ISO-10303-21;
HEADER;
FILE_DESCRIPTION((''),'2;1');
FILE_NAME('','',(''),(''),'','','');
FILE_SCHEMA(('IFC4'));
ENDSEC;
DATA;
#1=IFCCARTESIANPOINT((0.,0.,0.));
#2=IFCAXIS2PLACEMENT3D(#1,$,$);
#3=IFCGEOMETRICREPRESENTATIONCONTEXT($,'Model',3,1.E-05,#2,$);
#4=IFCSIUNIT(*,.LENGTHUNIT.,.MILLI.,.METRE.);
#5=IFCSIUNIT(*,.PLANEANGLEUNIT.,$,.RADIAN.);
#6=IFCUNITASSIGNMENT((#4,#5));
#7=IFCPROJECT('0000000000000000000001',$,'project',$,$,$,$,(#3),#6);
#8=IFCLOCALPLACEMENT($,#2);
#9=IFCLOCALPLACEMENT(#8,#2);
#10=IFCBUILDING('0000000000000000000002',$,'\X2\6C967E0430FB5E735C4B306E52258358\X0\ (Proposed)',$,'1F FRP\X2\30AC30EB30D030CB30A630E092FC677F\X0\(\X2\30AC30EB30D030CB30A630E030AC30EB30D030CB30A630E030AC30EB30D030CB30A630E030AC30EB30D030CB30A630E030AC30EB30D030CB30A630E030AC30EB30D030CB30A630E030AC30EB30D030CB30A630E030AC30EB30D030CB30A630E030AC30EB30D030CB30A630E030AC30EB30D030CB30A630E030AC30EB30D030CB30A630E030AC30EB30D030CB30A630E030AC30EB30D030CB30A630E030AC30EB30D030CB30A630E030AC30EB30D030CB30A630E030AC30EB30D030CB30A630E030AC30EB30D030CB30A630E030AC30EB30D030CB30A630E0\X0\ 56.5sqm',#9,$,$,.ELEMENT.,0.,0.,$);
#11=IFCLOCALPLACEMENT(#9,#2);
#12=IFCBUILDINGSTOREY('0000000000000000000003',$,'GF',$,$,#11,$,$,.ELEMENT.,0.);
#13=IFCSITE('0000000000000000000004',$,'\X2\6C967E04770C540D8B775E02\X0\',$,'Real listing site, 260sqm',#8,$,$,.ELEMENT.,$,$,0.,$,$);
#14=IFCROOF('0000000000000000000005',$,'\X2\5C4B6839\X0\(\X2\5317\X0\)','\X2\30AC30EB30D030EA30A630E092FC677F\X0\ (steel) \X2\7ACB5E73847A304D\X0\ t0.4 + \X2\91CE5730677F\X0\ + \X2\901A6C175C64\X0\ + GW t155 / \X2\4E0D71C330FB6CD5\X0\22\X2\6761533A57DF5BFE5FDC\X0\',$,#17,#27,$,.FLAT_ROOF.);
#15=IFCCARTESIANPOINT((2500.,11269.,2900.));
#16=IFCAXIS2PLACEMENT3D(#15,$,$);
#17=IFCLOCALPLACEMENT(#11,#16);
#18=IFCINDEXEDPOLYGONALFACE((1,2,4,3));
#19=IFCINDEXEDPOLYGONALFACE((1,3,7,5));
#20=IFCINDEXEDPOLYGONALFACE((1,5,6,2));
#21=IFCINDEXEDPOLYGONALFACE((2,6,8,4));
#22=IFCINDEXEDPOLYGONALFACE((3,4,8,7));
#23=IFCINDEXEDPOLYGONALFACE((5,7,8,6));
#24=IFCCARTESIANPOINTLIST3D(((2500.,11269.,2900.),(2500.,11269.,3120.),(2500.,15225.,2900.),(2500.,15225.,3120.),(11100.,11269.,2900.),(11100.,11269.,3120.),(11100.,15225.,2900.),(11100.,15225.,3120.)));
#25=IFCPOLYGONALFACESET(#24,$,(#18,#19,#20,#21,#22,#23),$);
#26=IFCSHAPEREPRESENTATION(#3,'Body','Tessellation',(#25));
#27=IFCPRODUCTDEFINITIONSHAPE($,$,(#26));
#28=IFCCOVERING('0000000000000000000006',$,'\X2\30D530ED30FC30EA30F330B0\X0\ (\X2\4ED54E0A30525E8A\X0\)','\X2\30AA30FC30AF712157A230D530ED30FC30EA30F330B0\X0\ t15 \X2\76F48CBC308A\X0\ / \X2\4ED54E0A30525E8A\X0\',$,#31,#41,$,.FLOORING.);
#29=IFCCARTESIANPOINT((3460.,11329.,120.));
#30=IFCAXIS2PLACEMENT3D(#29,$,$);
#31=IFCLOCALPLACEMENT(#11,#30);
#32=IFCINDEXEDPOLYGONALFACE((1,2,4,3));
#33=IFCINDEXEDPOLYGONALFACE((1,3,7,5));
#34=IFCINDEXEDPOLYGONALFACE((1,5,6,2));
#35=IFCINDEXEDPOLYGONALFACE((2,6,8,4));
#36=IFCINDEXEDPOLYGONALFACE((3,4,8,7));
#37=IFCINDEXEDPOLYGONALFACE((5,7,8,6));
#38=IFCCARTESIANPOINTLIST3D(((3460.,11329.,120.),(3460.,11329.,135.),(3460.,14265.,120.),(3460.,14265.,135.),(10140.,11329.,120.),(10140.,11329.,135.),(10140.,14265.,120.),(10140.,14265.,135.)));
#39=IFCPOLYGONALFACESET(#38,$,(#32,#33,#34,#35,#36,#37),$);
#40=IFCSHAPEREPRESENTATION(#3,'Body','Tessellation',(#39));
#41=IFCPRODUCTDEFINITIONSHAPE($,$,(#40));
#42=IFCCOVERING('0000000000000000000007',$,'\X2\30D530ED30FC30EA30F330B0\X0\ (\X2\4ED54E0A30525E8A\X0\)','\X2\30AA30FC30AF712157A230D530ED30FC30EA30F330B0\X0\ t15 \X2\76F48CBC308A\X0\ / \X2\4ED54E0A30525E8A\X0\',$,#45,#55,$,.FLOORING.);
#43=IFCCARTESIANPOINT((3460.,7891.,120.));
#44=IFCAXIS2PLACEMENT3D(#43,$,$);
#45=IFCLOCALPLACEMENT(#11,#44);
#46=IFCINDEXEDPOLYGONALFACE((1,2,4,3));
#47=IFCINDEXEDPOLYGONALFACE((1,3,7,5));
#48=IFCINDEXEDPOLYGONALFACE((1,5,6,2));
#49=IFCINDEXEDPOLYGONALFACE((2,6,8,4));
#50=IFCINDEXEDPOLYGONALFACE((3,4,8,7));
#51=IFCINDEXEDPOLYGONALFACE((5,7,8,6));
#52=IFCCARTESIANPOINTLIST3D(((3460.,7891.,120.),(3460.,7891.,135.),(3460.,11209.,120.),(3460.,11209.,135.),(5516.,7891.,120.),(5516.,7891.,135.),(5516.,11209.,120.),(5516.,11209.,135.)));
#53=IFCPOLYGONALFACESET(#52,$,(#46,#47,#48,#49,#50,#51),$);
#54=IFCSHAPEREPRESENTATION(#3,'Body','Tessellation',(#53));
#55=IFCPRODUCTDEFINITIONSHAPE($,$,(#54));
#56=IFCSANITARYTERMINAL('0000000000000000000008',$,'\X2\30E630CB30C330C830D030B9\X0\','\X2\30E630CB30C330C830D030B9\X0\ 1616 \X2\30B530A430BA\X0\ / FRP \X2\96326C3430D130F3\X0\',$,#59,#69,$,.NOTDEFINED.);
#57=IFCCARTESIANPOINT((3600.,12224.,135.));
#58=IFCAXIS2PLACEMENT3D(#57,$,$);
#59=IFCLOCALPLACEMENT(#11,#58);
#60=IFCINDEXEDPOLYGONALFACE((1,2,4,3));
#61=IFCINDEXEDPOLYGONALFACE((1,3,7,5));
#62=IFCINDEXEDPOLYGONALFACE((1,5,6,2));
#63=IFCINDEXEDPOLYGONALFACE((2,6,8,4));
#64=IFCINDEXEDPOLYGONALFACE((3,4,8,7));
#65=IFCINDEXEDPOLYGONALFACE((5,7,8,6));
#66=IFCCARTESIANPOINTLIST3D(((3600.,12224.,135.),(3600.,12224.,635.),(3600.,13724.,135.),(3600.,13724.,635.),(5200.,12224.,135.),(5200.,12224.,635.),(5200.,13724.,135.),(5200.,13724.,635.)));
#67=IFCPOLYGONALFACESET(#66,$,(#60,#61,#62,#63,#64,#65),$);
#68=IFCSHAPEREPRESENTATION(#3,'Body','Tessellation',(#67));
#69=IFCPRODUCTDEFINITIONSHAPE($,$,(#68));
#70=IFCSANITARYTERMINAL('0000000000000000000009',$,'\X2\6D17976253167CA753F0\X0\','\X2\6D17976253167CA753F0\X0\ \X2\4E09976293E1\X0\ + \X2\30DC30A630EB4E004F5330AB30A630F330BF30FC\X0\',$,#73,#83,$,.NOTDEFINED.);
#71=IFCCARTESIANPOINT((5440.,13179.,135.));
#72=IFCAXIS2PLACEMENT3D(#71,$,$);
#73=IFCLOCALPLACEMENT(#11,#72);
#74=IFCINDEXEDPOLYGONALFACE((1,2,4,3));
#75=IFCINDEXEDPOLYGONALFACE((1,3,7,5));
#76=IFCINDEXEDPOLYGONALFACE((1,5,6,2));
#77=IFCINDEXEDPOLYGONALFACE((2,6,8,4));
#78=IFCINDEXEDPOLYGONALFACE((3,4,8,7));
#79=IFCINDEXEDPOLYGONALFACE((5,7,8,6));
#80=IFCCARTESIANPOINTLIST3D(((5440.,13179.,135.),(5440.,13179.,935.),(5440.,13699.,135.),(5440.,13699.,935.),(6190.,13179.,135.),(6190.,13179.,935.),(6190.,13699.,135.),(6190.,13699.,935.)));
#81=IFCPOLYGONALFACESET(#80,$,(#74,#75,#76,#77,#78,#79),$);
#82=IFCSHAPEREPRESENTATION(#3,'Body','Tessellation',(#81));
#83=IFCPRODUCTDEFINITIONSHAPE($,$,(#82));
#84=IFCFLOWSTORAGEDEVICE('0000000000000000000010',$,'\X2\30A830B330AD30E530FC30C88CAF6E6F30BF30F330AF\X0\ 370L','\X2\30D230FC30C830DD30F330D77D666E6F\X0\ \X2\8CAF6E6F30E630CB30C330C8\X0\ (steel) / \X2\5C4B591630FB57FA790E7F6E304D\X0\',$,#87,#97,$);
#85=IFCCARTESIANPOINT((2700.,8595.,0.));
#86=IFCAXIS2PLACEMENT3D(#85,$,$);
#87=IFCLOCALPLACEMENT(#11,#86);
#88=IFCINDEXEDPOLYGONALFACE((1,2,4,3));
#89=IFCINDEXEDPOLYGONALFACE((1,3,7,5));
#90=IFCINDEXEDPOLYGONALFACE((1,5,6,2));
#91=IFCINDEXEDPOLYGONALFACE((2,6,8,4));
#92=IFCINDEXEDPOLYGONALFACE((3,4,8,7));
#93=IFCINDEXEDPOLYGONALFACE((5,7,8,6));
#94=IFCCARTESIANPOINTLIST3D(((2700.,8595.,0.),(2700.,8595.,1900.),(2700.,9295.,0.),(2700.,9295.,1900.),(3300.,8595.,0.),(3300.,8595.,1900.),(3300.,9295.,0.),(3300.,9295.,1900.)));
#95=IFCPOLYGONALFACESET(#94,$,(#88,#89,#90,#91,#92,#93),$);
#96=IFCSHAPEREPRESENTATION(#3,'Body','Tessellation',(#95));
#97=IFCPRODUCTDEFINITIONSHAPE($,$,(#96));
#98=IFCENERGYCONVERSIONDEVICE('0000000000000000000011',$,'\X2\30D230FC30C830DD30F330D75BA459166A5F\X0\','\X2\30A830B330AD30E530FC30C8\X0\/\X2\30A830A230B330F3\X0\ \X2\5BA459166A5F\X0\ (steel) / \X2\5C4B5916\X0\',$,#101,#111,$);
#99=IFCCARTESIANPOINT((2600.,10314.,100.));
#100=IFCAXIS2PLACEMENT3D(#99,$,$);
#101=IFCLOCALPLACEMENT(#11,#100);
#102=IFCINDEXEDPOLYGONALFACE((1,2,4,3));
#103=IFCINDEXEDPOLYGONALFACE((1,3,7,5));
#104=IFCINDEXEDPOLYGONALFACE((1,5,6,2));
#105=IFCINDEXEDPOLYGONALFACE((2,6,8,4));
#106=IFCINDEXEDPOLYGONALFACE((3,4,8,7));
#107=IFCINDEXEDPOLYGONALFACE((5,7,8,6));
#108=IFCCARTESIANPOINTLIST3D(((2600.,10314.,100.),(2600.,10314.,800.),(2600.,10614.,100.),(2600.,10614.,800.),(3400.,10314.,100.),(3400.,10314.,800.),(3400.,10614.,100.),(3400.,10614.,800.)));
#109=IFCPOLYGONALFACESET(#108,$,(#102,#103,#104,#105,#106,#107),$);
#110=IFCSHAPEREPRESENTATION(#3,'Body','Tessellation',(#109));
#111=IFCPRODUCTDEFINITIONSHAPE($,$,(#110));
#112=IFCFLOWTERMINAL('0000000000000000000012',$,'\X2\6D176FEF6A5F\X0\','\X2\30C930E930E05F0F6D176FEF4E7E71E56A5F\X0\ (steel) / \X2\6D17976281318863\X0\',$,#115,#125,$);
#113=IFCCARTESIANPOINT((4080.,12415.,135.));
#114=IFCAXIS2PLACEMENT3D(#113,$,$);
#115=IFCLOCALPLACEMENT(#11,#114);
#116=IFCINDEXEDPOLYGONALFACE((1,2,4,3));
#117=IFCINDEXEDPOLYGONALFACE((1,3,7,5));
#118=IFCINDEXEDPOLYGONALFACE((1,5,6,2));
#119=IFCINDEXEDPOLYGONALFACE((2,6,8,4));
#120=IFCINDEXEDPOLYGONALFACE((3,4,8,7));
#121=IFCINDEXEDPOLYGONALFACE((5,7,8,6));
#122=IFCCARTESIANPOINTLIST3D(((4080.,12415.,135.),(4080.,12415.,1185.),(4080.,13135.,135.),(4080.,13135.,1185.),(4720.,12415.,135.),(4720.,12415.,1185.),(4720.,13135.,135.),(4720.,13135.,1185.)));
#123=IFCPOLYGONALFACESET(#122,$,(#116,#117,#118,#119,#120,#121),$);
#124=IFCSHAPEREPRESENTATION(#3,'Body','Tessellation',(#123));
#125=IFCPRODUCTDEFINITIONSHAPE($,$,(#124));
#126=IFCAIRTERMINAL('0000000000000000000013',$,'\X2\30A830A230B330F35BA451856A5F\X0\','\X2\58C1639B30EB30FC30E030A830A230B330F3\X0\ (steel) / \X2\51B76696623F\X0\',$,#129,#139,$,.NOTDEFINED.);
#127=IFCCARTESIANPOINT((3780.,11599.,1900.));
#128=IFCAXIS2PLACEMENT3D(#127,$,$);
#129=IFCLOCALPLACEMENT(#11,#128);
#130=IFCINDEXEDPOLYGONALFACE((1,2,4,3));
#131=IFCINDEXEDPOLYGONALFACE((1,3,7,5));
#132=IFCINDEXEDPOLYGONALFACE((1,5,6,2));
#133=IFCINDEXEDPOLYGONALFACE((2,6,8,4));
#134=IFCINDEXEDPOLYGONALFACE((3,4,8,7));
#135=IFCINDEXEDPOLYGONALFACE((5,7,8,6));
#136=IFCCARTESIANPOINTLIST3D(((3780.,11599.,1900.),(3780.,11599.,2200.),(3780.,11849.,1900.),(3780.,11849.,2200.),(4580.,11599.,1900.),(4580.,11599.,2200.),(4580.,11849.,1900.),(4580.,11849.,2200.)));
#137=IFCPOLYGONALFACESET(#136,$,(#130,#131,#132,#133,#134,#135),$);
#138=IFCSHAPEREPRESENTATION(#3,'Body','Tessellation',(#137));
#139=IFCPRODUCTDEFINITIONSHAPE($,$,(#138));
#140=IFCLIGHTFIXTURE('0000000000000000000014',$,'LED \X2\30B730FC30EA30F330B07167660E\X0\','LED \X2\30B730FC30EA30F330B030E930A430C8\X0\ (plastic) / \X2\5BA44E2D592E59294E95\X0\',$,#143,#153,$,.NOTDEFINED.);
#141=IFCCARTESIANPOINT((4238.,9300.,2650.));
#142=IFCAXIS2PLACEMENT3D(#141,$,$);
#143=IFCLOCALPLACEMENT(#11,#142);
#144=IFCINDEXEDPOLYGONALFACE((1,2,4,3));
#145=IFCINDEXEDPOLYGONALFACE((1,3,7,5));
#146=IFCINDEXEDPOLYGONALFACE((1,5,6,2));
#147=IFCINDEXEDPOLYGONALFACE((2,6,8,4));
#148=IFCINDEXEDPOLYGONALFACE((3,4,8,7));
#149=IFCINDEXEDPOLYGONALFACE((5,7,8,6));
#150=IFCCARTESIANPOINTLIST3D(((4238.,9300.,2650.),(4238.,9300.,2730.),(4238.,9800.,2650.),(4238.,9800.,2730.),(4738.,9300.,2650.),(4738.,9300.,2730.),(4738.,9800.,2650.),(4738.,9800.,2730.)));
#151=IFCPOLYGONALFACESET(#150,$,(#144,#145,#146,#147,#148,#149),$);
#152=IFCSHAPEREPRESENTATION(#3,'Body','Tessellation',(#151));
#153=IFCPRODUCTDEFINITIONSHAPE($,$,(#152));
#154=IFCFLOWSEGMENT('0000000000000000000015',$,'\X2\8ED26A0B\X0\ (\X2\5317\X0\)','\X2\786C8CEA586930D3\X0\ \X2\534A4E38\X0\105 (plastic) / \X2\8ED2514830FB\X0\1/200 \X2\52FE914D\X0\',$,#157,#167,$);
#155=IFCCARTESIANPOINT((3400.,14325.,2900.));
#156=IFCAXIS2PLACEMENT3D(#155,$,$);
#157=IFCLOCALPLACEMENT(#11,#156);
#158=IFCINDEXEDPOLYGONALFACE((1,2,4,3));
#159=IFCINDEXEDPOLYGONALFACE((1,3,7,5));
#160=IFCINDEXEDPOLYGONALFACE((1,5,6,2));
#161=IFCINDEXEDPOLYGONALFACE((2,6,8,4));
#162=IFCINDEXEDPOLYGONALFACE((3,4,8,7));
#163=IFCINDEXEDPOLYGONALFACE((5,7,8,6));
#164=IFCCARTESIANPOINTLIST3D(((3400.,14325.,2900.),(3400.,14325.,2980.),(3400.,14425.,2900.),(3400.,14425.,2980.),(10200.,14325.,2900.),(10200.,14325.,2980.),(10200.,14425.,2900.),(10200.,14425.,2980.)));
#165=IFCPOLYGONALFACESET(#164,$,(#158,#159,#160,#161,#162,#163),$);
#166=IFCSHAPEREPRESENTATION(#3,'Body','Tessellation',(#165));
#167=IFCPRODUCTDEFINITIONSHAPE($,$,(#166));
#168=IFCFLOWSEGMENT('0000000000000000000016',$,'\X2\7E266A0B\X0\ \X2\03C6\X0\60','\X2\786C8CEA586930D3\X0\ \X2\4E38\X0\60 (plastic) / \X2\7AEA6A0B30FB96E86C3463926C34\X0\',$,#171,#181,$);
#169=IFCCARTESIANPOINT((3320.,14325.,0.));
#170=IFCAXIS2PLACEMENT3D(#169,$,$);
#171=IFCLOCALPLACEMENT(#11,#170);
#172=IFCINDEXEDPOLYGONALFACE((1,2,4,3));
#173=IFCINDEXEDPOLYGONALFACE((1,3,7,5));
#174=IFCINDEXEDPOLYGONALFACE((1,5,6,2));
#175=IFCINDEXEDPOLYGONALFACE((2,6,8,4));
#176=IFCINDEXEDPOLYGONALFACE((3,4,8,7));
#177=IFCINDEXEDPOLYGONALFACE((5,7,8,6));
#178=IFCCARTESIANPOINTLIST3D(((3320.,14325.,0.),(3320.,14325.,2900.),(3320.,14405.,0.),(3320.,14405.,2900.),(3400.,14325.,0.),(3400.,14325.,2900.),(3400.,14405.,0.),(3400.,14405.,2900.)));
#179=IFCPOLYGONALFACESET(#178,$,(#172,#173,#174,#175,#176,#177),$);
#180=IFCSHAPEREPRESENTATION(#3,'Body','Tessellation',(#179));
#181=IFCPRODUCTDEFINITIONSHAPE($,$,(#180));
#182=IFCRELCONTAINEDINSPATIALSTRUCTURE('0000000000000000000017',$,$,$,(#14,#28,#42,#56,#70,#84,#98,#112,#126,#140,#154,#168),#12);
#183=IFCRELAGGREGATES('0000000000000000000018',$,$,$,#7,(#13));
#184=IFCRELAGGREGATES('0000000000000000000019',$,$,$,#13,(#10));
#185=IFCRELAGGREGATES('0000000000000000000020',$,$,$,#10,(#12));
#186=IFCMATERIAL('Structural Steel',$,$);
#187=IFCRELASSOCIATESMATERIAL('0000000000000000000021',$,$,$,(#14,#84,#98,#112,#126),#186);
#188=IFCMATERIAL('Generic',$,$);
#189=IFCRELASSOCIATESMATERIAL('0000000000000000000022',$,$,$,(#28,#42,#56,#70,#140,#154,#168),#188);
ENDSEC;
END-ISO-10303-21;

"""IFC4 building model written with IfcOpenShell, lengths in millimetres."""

from ifc_helpers import new_model, si_unit, frame, frame_2d, origin, place, context, project, spatial, rectangle, extrude, material, element, save


model = new_model("IFC4")

# Units and contexts
model_context = context("Model", 3, precision=1e-05, world=origin())
ifc_project = project(units=[si_unit("LENGTHUNIT", "METRE", prefix="MILLI"), si_unit("PLANEANGLEUNIT", "RADIAN")], contexts=[model_context])

# Site, building, storey
site_placement = place(None, origin())
site = spatial("IfcSite", under=ifc_project, at=site_placement, Name="沖縄県名護市", ObjectType="Real listing site, 260sqm", CompositionType="ELEMENT", RefElevation=0.0)
building_placement = place(site_placement, origin())
building = spatial("IfcBuilding", under=site, at=building_placement, Name="沖縄・平屋の別荘 (Proposed)", ObjectType="1F FRPガルバニウム鋼板(ガルバニウムガルバニウムガルバニウムガルバニウムガルバニウムガルバニウムガルバニウムガルバニウムガルバニウムガルバニウムガルバニウムガルバニウムガルバニウムガルバニウムガルバニウムガルバニウムガルバニウムガルバニウム 56.5sqm", CompositionType="ELEMENT", ElevationOfRefHeight=0.0, ElevationOfTerrain=0.0)
storey_placement = place(building_placement, origin())
storey = spatial("IfcBuildingStorey", under=building, at=storey_placement, Name="GF", CompositionType="ELEMENT", Elevation=0.0)

# Roof
ifc_material_1 = material(Name="Structural Steel")
roof_placement = place(storey_placement, frame((2500.0, 11269.0, 2900.0)))
element("IfcRoof", 1, at=roof_placement, inside=storey, material=ifc_material_1, Name="屋根(北)", Description="ガルバリウム鋼板 (steel) 立平葺き t0.4 + 野地板 + 通気層 + GW t155 / 不燃・法22条区域対応", PredefinedType="FLAT_ROOF", context=model_context, shape_type="SweptSolid", body=[
    extrude(rectangle(XDim=8600.0, YDim=3956.0, at=frame_2d((4300.0, 1978.0))), frame((2500.0, 11269.0, 2900.0)), (0.0, 0.0, 1.0), 220.0),
])

# Coverings
ifc_material_2 = material(Name="Generic")
covering_1_placement = place(storey_placement, frame((3460.0, 11329.0, 120.0)))
element("IfcCovering", 2, at=covering_1_placement, inside=storey, material=ifc_material_2, Name="フローリング (仕上げ床)", Description="オーク無垢フローリング t15 直貼り / 仕上げ床", PredefinedType="FLOORING", context=model_context, shape_type="SweptSolid", body=[
    extrude(rectangle(XDim=6680.0, YDim=2936.0, at=frame_2d((3340.0, 1468.0))), frame((3460.0, 11329.0, 120.0)), (0.0, 0.0, 1.0), 15.0),
])
covering_2_placement = place(storey_placement, frame((3460.0, 7891.0, 120.0)))
element("IfcCovering", 3, at=covering_2_placement, inside=storey, material=ifc_material_2, Name="フローリング (仕上げ床)", Description="オーク無垢フローリング t15 直貼り / 仕上げ床", PredefinedType="FLOORING", context=model_context, shape_type="SweptSolid", body=[
    extrude(rectangle(XDim=2056.0, YDim=3318.0, at=frame_2d((1028.0, 1659.0))), frame((3460.0, 7891.0, 120.0)), (0.0, 0.0, 1.0), 15.0),
])

# Sanitary terminals
sanitary_terminal_1_placement = place(storey_placement, frame((3600.0, 12224.0, 135.0)))
element("IfcSanitaryTerminal", 4, at=sanitary_terminal_1_placement, inside=storey, material=ifc_material_2, Name="ユニットバス", Description="ユニットバス 1616 サイズ / FRP 防水パン", PredefinedType="NOTDEFINED", context=model_context, shape_type="SweptSolid", body=[
    extrude(rectangle(XDim=1600.0, YDim=1500.0, at=frame_2d((800.0, 750.0))), frame((3600.0, 12224.0, 135.0)), (0.0, 0.0, 1.0), 500.0),
])
sanitary_terminal_2_placement = place(storey_placement, frame((5440.0, 13179.0, 135.0)))
element("IfcSanitaryTerminal", 5, at=sanitary_terminal_2_placement, inside=storey, material=ifc_material_2, Name="洗面化粧台", Description="洗面化粧台 三面鏡 + ボウル一体カウンター", PredefinedType="NOTDEFINED", context=model_context, shape_type="SweptSolid", body=[
    extrude(rectangle(XDim=750.0, YDim=520.0, at=frame_2d((375.0, 260.0))), frame((5440.0, 13179.0, 135.0)), (0.0, 0.0, 1.0), 800.0),
])

# Flow storage device
flow_storage_device_placement = place(storey_placement, frame((2700.0, 8595.0, 0.0)))
element("IfcFlowStorageDevice", 6, at=flow_storage_device_placement, inside=storey, material=ifc_material_1, Name="エコキュート貯湯タンク 370L", Description="ヒートポンプ給湯 貯湯ユニット (steel) / 屋外・基礎置き", context=model_context, shape_type="SweptSolid", body=[
    extrude(rectangle(XDim=600.0, YDim=700.0, at=frame_2d((300.0, 350.0))), frame((2700.0, 8595.0, 0.0)), (0.0, 0.0, 1.0), 1900.0),
])

# Energy conversion device
energy_conversion_device_placement = place(storey_placement, frame((2600.0, 10314.0, 100.0)))
element("IfcEnergyConversionDevice", 7, at=energy_conversion_device_placement, inside=storey, material=ifc_material_1, Name="ヒートポンプ室外機", Description="エコキュート/エアコン 室外機 (steel) / 屋外", context=model_context, shape_type="SweptSolid", body=[
    extrude(rectangle(XDim=800.0, YDim=300.0, at=frame_2d((400.0, 150.0))), frame((2600.0, 10314.0, 100.0)), (0.0, 0.0, 1.0), 700.0),
])

# Flow terminal
flow_terminal_placement = place(storey_placement, frame((4080.0, 12415.0, 135.0)))
element("IfcFlowTerminal", 8, at=flow_terminal_placement, inside=storey, material=ifc_material_1, Name="洗濯機", Description="ドラム式洗濯乾燥機 (steel) / 洗面脱衣", context=model_context, shape_type="SweptSolid", body=[
    extrude(rectangle(XDim=640.0, YDim=720.0, at=frame_2d((320.0, 360.0))), frame((4080.0, 12415.0, 135.0)), (0.0, 0.0, 1.0), 1050.0),
])

# Air terminal
air_terminal_placement = place(storey_placement, frame((3780.0, 11599.0, 1900.0)))
element("IfcAirTerminal", 9, at=air_terminal_placement, inside=storey, material=ifc_material_1, Name="エアコン室内機", Description="壁掛ルームエアコン (steel) / 冷暖房", PredefinedType="NOTDEFINED", context=model_context, shape_type="SweptSolid", body=[
    extrude(rectangle(XDim=800.0, YDim=250.0, at=frame_2d((400.0, 125.0))), frame((3780.0, 11599.0, 1900.0)), (0.0, 0.0, 1.0), 300.0),
])

# Light fixture
light_fixture_placement = place(storey_placement, frame((4238.0, 9300.0, 2650.0)))
element("IfcLightFixture", 10, at=light_fixture_placement, inside=storey, material=ifc_material_2, Name="LED シーリング照明", Description="LED シーリングライト (plastic) / 室中央天井", PredefinedType="NOTDEFINED", context=model_context, shape_type="SweptSolid", body=[
    extrude(rectangle(XDim=500.0, YDim=500.0, at=frame_2d((250.0, 250.0))), frame((4238.0, 9300.0, 2650.0)), (0.0, 0.0, 1.0), 80.0),
])

# Flow segments
flow_segment_1_placement = place(storey_placement, frame((3400.0, 14325.0, 2900.0)))
element("IfcFlowSegment", 11, at=flow_segment_1_placement, inside=storey, material=ifc_material_2, Name="軒樋 (北)", Description="硬質塩ビ 半丸105 (plastic) / 軒先・1/200 勾配", context=model_context, shape_type="SweptSolid", body=[
    extrude(rectangle(XDim=6800.0, YDim=100.0, at=frame_2d((3400.0, 50.0))), frame((3400.0, 14325.0, 2900.0)), (0.0, 0.0, 1.0), 80.0),
])
flow_segment_2_placement = place(storey_placement, frame((3320.0, 14325.0, 0.0)))
element("IfcFlowSegment", 12, at=flow_segment_2_placement, inside=storey, material=ifc_material_2, Name="縦樋 φ60", Description="硬質塩ビ 丸60 (plastic) / 竪樋・雨水排水", context=model_context, shape_type="SweptSolid", body=[
    extrude(rectangle(XDim=80.0, YDim=80.0, at=frame_2d((40.0, 40.0))), frame((3320.0, 14325.0, 0.0)), (0.0, 0.0, 1.0), 2900.0),
])

save(model, "model.ifc")
